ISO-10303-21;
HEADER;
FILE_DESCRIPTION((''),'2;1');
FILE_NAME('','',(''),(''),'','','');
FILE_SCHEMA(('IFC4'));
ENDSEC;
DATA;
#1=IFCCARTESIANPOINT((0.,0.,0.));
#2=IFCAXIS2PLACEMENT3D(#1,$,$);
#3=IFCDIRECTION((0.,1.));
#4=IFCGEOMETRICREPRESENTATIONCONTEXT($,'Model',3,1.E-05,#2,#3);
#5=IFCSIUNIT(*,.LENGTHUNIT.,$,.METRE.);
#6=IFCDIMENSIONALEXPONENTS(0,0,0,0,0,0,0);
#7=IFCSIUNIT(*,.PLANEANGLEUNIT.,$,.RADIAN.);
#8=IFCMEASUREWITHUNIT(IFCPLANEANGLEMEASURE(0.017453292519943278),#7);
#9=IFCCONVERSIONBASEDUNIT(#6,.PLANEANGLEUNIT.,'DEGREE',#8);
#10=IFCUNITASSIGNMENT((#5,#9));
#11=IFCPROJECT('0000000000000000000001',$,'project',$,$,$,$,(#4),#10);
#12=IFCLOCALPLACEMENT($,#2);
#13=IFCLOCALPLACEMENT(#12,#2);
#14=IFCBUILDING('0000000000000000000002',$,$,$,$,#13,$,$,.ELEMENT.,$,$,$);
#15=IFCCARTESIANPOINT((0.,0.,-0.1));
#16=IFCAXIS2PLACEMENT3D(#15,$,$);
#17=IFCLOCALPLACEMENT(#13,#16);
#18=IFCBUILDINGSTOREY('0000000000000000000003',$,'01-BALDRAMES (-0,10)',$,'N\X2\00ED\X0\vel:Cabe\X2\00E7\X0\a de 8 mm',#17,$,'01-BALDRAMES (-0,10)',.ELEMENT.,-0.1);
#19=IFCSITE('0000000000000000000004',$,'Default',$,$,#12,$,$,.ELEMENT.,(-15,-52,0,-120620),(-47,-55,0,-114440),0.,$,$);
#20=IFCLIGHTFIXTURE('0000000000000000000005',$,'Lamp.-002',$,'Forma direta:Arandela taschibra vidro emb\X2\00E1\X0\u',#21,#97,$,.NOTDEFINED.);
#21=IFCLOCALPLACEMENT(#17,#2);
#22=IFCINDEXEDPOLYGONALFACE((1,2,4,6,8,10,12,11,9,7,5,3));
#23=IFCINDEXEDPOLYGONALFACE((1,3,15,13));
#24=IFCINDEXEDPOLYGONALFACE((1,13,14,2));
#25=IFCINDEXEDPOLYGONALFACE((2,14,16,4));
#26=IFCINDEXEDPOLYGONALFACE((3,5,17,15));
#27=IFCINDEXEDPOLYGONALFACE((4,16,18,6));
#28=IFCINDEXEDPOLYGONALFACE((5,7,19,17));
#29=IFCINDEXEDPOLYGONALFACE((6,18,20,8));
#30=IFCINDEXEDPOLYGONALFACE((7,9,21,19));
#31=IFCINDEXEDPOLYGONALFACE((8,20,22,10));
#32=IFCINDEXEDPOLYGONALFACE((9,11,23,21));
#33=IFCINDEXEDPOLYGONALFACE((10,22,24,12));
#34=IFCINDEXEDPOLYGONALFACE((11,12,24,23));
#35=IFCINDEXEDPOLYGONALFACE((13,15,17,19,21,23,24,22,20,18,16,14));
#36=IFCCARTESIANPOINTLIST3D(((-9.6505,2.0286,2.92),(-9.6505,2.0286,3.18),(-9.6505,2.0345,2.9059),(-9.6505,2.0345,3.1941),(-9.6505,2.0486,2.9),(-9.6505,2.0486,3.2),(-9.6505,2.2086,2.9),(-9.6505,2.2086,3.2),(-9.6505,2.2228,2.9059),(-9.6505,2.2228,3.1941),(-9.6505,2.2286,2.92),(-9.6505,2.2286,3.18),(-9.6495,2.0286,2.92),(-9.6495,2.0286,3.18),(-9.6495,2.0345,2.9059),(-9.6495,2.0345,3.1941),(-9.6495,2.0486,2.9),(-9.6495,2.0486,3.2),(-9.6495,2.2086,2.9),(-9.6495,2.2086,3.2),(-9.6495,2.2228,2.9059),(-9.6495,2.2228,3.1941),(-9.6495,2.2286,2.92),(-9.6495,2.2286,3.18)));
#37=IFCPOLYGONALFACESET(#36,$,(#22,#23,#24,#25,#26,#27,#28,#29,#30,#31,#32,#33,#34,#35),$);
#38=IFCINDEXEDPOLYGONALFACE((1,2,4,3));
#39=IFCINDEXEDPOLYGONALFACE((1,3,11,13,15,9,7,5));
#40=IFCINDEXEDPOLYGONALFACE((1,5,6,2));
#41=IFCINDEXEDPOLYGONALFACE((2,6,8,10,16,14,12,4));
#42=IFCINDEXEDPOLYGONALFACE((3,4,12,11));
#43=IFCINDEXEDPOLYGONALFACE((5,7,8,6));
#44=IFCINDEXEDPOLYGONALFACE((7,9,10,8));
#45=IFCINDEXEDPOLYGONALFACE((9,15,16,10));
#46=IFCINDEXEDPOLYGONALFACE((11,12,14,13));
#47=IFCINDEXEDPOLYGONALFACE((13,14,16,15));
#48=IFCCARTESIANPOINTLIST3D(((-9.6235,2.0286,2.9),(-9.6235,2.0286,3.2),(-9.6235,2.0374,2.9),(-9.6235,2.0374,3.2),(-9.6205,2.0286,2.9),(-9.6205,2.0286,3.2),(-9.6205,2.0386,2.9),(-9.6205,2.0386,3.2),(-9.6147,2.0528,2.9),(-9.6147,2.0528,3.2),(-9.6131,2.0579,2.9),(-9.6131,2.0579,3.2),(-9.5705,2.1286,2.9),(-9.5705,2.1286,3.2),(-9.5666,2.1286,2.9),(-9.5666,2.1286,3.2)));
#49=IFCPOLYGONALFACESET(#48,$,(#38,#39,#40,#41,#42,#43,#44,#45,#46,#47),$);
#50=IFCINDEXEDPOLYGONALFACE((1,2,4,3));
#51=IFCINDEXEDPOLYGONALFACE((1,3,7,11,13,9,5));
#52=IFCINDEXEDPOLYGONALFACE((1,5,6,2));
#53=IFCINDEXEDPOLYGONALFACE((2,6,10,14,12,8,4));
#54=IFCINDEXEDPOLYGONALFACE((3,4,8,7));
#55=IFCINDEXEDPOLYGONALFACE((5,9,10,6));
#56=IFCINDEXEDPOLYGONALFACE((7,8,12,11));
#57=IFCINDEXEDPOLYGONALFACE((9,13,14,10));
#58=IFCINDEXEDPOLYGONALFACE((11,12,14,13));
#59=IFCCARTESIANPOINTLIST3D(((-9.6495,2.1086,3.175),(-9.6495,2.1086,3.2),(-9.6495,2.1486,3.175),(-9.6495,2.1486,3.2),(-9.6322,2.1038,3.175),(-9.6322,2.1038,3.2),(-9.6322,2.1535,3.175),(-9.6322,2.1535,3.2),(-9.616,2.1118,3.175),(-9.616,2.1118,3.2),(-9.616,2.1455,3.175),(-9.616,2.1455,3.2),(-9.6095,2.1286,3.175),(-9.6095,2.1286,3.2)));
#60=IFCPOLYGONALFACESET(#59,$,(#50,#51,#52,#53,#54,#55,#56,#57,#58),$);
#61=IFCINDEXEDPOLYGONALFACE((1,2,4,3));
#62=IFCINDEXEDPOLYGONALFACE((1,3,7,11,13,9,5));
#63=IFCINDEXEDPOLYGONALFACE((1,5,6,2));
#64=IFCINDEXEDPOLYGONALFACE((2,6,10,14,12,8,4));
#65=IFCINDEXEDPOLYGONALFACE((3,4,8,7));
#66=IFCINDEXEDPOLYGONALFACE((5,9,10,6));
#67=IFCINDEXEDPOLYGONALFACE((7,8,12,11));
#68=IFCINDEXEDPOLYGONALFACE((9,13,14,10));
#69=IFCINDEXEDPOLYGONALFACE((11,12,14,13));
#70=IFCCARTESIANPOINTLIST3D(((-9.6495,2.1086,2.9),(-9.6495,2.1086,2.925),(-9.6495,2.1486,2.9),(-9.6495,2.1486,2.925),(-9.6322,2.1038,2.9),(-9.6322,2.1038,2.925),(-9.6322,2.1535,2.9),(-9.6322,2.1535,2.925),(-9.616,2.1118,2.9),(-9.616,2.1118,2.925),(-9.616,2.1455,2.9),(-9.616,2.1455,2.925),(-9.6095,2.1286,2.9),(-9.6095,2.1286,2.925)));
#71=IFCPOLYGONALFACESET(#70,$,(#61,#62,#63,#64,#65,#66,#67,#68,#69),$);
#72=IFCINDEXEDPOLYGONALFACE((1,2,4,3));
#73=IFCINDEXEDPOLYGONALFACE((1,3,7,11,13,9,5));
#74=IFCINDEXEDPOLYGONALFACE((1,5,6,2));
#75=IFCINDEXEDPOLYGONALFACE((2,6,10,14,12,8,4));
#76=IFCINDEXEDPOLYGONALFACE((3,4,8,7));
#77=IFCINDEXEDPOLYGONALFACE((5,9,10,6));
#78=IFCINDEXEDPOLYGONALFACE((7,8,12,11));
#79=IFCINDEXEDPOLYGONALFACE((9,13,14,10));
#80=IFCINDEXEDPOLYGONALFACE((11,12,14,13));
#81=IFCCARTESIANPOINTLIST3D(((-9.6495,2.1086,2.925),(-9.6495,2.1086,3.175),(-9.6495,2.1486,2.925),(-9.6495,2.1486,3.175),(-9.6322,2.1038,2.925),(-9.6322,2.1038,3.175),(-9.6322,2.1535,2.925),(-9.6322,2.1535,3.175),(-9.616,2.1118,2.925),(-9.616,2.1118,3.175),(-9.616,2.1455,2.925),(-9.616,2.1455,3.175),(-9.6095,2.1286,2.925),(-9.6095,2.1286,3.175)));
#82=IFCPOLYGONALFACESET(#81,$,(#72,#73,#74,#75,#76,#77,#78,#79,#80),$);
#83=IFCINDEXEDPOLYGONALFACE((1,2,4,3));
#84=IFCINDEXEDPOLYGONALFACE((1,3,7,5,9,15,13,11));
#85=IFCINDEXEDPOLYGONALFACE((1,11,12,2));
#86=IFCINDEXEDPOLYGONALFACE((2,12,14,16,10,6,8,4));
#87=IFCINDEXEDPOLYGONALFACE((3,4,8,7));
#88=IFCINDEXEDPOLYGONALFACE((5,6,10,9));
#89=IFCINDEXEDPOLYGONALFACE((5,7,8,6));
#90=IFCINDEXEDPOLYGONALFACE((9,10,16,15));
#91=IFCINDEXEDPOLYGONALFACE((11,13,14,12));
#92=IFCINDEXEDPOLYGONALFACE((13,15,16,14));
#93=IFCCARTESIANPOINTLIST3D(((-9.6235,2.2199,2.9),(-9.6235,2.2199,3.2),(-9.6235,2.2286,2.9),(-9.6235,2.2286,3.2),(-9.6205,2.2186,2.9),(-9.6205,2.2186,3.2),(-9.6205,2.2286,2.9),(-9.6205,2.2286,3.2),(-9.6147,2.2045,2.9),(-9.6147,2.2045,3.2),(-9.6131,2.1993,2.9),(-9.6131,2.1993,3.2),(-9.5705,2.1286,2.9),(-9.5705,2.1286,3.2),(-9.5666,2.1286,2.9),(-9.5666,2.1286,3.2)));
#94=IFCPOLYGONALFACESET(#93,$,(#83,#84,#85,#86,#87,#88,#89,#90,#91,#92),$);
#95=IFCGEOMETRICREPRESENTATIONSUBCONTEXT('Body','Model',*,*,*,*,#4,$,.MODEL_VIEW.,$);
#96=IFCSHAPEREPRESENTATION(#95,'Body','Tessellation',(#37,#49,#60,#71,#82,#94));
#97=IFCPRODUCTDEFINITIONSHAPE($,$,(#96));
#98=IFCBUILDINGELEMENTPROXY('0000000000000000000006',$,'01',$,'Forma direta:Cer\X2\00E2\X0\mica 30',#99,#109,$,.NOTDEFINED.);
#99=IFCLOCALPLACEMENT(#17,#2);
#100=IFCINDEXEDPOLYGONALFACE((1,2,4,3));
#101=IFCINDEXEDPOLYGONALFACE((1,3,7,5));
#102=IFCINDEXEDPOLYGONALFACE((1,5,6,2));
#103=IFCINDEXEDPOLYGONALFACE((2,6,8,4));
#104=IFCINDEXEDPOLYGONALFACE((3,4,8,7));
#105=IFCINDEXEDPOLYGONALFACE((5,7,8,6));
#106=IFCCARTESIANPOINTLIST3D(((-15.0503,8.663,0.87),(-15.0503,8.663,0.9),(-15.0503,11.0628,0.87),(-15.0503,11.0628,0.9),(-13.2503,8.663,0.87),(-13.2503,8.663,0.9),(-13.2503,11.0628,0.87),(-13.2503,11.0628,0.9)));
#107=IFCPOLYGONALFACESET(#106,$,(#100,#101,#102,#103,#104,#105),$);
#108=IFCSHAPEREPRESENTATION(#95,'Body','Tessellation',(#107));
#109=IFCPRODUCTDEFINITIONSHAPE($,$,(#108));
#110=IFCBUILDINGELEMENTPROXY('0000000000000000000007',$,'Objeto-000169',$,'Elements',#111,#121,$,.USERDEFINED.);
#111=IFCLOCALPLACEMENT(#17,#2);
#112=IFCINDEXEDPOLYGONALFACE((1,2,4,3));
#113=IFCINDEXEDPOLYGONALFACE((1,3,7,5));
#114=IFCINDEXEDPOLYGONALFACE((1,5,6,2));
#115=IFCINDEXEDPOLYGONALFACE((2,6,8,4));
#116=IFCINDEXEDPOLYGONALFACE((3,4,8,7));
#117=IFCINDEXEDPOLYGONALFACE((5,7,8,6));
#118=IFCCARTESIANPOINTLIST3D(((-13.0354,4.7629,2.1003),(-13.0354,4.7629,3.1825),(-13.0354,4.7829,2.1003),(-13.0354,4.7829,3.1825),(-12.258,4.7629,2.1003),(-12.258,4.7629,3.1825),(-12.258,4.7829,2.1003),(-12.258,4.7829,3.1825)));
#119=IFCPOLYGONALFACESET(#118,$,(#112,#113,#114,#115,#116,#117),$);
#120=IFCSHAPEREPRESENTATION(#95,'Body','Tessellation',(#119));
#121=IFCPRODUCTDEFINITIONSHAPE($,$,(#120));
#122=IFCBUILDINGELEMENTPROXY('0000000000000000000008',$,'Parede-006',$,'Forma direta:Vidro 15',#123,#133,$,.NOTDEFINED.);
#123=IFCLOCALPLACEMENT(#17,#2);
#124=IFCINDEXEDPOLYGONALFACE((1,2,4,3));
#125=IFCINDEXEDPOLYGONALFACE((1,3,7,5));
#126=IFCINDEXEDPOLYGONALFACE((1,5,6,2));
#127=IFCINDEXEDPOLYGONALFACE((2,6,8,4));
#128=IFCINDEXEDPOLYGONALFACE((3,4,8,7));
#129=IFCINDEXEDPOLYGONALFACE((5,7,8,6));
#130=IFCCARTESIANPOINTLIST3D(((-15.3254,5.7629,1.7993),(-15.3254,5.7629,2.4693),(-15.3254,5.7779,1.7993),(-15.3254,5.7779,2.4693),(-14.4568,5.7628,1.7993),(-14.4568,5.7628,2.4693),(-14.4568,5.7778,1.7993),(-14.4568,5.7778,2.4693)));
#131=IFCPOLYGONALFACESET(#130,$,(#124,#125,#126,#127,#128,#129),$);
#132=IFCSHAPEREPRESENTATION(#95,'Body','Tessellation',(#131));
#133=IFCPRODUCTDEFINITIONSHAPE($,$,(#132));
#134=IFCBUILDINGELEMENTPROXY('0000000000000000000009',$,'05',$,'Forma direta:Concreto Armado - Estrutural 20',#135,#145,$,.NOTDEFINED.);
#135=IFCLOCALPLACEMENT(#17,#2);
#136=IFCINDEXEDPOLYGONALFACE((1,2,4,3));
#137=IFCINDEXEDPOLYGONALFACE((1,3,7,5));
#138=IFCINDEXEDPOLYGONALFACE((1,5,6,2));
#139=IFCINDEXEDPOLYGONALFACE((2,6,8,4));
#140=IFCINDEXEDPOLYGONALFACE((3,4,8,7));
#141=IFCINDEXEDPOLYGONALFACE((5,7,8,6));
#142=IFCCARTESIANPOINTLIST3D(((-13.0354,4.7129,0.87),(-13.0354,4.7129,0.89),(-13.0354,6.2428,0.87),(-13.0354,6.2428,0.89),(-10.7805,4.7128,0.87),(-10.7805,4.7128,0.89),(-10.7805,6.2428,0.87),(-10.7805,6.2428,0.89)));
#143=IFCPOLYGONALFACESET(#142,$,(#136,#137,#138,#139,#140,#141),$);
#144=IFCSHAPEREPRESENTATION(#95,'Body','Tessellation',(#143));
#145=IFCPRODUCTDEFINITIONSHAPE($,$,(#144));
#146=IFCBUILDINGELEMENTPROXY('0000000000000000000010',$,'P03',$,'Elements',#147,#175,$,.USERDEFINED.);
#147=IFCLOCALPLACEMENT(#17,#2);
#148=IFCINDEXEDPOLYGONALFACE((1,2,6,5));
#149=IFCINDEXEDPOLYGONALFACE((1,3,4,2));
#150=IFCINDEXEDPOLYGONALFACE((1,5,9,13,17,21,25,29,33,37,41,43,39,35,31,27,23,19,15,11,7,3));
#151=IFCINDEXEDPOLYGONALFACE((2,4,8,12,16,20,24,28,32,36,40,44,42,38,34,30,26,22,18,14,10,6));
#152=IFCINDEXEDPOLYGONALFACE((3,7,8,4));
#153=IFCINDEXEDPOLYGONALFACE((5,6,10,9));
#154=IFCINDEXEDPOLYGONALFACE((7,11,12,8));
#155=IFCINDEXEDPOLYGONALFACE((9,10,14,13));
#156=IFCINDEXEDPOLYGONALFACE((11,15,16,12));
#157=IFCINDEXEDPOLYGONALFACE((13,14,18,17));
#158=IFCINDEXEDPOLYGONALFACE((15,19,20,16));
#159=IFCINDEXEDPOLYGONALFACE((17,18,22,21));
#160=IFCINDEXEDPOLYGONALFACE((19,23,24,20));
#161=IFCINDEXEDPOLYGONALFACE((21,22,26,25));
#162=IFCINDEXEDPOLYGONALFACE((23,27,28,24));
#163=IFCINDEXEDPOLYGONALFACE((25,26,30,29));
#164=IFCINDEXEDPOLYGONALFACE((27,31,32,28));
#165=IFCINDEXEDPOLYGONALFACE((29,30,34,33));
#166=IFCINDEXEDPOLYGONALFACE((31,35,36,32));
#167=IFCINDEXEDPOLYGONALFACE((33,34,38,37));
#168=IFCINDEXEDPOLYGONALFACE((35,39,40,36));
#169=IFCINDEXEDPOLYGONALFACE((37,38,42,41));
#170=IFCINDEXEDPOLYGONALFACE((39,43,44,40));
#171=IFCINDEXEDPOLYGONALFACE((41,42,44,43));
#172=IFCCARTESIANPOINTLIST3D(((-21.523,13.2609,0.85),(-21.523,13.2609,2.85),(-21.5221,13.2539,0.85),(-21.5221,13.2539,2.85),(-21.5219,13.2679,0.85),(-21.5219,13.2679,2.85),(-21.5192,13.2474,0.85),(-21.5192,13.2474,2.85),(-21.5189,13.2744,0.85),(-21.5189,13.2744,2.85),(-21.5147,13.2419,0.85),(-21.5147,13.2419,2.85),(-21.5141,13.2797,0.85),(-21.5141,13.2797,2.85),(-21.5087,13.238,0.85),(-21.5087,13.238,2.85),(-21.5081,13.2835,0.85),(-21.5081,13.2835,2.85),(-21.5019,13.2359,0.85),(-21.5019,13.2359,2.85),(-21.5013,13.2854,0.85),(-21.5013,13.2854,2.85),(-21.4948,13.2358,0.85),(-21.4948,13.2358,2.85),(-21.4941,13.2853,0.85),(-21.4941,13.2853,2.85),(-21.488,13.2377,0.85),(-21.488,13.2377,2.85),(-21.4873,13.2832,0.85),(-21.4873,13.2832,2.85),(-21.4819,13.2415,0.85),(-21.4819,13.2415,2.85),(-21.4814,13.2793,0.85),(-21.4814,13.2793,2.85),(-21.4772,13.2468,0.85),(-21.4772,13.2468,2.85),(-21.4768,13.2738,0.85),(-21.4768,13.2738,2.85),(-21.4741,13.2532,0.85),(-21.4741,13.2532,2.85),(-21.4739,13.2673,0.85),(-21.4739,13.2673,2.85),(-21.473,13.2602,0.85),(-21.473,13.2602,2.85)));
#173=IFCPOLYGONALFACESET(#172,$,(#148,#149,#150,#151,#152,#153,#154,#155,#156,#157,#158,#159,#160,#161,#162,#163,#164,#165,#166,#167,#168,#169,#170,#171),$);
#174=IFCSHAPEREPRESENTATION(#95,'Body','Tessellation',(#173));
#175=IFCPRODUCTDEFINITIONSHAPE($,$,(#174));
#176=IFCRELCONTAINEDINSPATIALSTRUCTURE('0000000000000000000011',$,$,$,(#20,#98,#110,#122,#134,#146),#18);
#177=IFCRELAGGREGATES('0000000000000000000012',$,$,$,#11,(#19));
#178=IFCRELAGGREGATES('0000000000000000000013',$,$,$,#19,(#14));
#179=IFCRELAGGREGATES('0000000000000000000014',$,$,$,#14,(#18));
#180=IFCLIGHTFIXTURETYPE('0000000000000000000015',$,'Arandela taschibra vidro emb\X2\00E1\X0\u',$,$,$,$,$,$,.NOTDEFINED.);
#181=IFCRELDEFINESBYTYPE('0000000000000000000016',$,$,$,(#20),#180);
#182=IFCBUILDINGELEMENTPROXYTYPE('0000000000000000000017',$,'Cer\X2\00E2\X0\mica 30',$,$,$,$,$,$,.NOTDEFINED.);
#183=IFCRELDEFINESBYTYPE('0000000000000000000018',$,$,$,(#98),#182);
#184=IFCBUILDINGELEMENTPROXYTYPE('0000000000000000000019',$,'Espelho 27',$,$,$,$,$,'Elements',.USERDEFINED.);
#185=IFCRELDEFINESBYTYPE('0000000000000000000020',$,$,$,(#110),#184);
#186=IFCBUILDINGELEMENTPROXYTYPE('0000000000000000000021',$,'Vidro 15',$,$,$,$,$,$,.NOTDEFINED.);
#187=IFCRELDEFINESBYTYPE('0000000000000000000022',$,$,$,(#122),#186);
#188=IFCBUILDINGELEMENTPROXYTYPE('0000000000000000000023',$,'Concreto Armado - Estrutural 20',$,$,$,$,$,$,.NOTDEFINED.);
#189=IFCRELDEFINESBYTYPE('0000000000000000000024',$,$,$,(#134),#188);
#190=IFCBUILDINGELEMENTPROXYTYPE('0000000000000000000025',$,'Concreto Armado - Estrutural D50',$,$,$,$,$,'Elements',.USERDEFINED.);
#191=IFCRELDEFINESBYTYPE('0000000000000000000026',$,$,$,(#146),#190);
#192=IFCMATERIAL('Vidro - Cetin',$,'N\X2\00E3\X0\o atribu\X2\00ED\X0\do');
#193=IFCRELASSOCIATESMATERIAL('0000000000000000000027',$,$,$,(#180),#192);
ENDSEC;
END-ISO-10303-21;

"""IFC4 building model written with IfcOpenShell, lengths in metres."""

from ifc_helpers import new_model, entity, si_unit, converted_unit, direction, frame, origin, place, context, subcontext, project, spatial, arc, indexed_curve, outline, extrude, material, type_object, element, save


model = new_model("IFC4")

# Units and contexts
model_context = context("Model", 3, precision=1e-05, world=origin(), true_north=direction((0.0, 1.0)))
body_context = subcontext(model_context, "Body", "Model", "MODEL_VIEW")
ifc_project = project(units=[si_unit("LENGTHUNIT", "METRE"), converted_unit("PLANEANGLEUNIT", "DEGREE", entity("IfcPlaneAngleMeasure", 0.017453292519943278), si_unit("PLANEANGLEUNIT", "RADIAN"), dimensions=[0, 0, 0, 0, 0, 0, 0])], contexts=[model_context])

# Site, building, storey
site_placement = place(None, origin())
site = spatial("IfcSite", under=ifc_project, at=site_placement, Name="Default", CompositionType="ELEMENT", RefLatitude=(-15, -52, 0, -120620), RefLongitude=(-47, -55, 0, -114440), RefElevation=0.0)
building_placement = place(site_placement, origin())
building = spatial("IfcBuilding", under=site, at=building_placement, CompositionType="ELEMENT")
storey_placement = place(building_placement, frame((0.0, 0.0, -0.1)))
storey = spatial("IfcBuildingStorey", under=building, at=storey_placement, Name="01-BALDRAMES (-0,10)", ObjectType="Nível:Cabeça de 8 mm", LongName="01-BALDRAMES (-0,10)", CompositionType="ELEMENT", Elevation=-0.1)

# Light fixture
ifc_material_1 = material(Name="Vidro - Cetin", Category="Não atribuído")
light_fixture_type_1 = type_object("IfcLightFixtureType", Name="Arandela taschibra vidro embáu", PredefinedType="NOTDEFINED", material=ifc_material_1)
light_fixture_1_placement = place(storey_placement, origin())
element("IfcLightFixture", 1, at=light_fixture_1_placement, inside=storey, type_object=light_fixture_type_1, Name="Lamp.-002", ObjectType="Forma direta:Arandela taschibra vidro embáu", PredefinedType="NOTDEFINED", context=body_context, shape_type="SweptSolid", body=[
    extrude(outline(indexed_curve([(0.0165, -0.1692), (0.0318, -0.1692), (0.0426, -0.1584), (0.1421, 0.0818), (0.1421, 0.0971), (0.1313, 0.108), (-0.0165, 0.1692), (-0.0318, 0.1692), (-0.0426, 0.1584), (-0.1421, -0.0818), (-0.1421, -0.0971), (-0.1313, -0.108), (0.0165, -0.1692)], self_intersect=False)), frame((-9.6505, 2.1286, 3.05), z_axis=(1.0, -0.000013, 0.0), x_axis=(0.000012, 0.92388, 0.382683)), (0.0, 0.0, 1.0), 0.001),
    extrude(outline(indexed_curve([(-0.0169, -0.034), (-0.0139, -0.034), (-0.0139, -0.024), (-0.008, -0.0099), (0.04, 0.066), (0.0361, 0.066), (-0.0065, -0.0047), (-0.0169, -0.0253), (-0.0169, -0.034)], self_intersect=False)), frame((-9.6066, 2.0627, 2.9)), (0.0, 0.0, 1.0), 0.3),
    extrude(outline(indexed_curve([(-0.0141, -0.0247), (0.004, -0.0247), (0.0173, -0.0126), (0.019, 0.0054), (0.0082, 0.0198), (-0.0095, 0.0232), (-0.0249, 0.0138), (-0.0141, -0.0247)], self_intersect=False)), frame((-9.6293, 2.1286, 3.175), z_axis=(0.0, 0.0, 1.0), x_axis=(0.96257, -0.271031, 0.0)), (0.0, 0.0, 1.0), 0.025),
    extrude(outline(indexed_curve([(-0.0141, -0.0247), (0.004, -0.0247), (0.0173, -0.0126), (0.019, 0.0054), (0.0082, 0.0198), (-0.0095, 0.0232), (-0.0249, 0.0138), (-0.0141, -0.0247)], self_intersect=False)), frame((-9.6293, 2.1286, 2.9), z_axis=(0.0, 0.0, 1.0), x_axis=(0.96257, -0.271031, 0.0)), (0.0, 0.0, 1.0), 0.025),
    extrude(outline(indexed_curve([(-0.0141, -0.0247), (0.004, -0.0247), (0.0173, -0.0126), (0.019, 0.0054), (0.0082, 0.0198), (-0.0095, 0.0232), (-0.0249, 0.0138), (-0.0141, -0.0247)], self_intersect=False)), frame((-9.6293, 2.1286, 2.925), z_axis=(0.0, 0.0, 1.0), x_axis=(0.96257, -0.271031, 0.0)), (0.0, 0.0, 1.0), 0.25),
    extrude(outline(indexed_curve([(-0.034, -0.0169), (-0.0253, -0.0169), (-0.0047, -0.0065), (0.066, 0.0361), (0.066, 0.04), (-0.0099, -0.008), (-0.024, -0.0139), (-0.034, -0.0139), (-0.034, -0.0169)], self_intersect=False)), frame((-9.6066, 2.1946, 2.9), z_axis=(0.0, 0.0, 1.0), x_axis=(0.000426, -1.0, 0.0)), (0.0, 0.0, 1.0), 0.3),
])

# Building element proxies
building_element_proxy_type_1 = type_object("IfcBuildingElementProxyType", Name="Cerâmica 30", PredefinedType="NOTDEFINED")
proxy_1_placement = place(storey_placement, origin())
element("IfcBuildingElementProxy", 2, at=proxy_1_placement, inside=storey, type_object=building_element_proxy_type_1, Name="01", ObjectType="Forma direta:Cerâmica 30", PredefinedType="NOTDEFINED", context=body_context, shape_type="SweptSolid", body=[
    extrude(outline(indexed_curve([(-0.9, -1.1999), (0.9, -1.1999), (0.9, 1.1999), (-0.9, 1.1999), (-0.9, -1.1999)], self_intersect=False)), frame((-14.1503, 9.8629, 0.87)), (0.0, 0.0, 1.0), 0.03),
])
building_element_proxy_type_2 = type_object("IfcBuildingElementProxyType", Name="Espelho 27", ElementType="Elements", PredefinedType="USERDEFINED")
proxy_2_placement = place(storey_placement, origin())
element("IfcBuildingElementProxy", 3, at=proxy_2_placement, inside=storey, type_object=building_element_proxy_type_2, Name="Objeto-000169", ObjectType="Elements", PredefinedType="USERDEFINED", context=body_context, shape_type="SweptSolid", body=[
    extrude(outline(indexed_curve([(-0.3887, -0.01), (0.3887, -0.01), (0.3887, 0.01), (-0.3887, 0.01), (-0.3887, -0.01)], self_intersect=False)), frame((-12.6467, 4.7729, 2.1003)), (0.0, 0.0, 1.0), 1.0822),
])
building_element_proxy_type_3 = type_object("IfcBuildingElementProxyType", Name="Vidro 15", PredefinedType="NOTDEFINED")
proxy_3_placement = place(storey_placement, origin())
element("IfcBuildingElementProxy", 4, at=proxy_3_placement, inside=storey, type_object=building_element_proxy_type_3, Name="Parede-006", ObjectType="Forma direta:Vidro 15", PredefinedType="NOTDEFINED", context=body_context, shape_type="SweptSolid", body=[
    extrude(outline(indexed_curve([(-0.0075, -0.4343), (0.0075, -0.4343), (0.0075, 0.4343), (-0.0075, 0.4343), (-0.0075, -0.4343)], self_intersect=False)), frame((-14.8911, 5.7703, 1.7993), z_axis=(0.0, 0.0, 1.0), x_axis=(0.000013, 1.0, 0.0)), (0.0, 0.0, 1.0), 0.67),
])
building_element_proxy_type_4 = type_object("IfcBuildingElementProxyType", Name="Concreto Armado - Estrutural 20", PredefinedType="NOTDEFINED")
proxy_4_placement = place(storey_placement, origin())
element("IfcBuildingElementProxy", 5, at=proxy_4_placement, inside=storey, type_object=building_element_proxy_type_4, Name="05", ObjectType="Forma direta:Concreto Armado - Estrutural 20", PredefinedType="NOTDEFINED", context=body_context, shape_type="SweptSolid", body=[
    extrude(outline(indexed_curve([(-0.765, -1.1274), (0.765, -1.1274), (0.765, 1.1274), (-0.765, 1.1274), (-0.765, -1.1274)], self_intersect=False)), frame((-11.908, 5.4778, 0.87), z_axis=(0.0, 0.0, 1.0), x_axis=(0.000013, 1.0, 0.0)), (0.0, 0.0, 1.0), 0.02),
])
building_element_proxy_type_5 = type_object("IfcBuildingElementProxyType", Name="Concreto Armado - Estrutural D50", ElementType="Elements", PredefinedType="USERDEFINED")
proxy_5_placement = place(storey_placement, origin())
element("IfcBuildingElementProxy", 6, at=proxy_5_placement, inside=storey, type_object=building_element_proxy_type_5, Name="P03", ObjectType="Elements", PredefinedType="USERDEFINED", context=body_context, shape_type="SweptSolid", body=[
    extrude(outline(indexed_curve([(0.025, 0.0), (0.0, 0.025), (-0.025, 0.0), (0.0, -0.025)], segments=[arc(1, 2, 3), arc(3, 4, 1)], self_intersect=False)), frame((-21.498, 13.2606, 0.85), z_axis=(0.0, 0.0, 1.0), x_axis=(0.665024, 0.746822, 0.0)), (0.0, 0.0, 1.0), 2.0),
])

save(model, "model.ifc")
